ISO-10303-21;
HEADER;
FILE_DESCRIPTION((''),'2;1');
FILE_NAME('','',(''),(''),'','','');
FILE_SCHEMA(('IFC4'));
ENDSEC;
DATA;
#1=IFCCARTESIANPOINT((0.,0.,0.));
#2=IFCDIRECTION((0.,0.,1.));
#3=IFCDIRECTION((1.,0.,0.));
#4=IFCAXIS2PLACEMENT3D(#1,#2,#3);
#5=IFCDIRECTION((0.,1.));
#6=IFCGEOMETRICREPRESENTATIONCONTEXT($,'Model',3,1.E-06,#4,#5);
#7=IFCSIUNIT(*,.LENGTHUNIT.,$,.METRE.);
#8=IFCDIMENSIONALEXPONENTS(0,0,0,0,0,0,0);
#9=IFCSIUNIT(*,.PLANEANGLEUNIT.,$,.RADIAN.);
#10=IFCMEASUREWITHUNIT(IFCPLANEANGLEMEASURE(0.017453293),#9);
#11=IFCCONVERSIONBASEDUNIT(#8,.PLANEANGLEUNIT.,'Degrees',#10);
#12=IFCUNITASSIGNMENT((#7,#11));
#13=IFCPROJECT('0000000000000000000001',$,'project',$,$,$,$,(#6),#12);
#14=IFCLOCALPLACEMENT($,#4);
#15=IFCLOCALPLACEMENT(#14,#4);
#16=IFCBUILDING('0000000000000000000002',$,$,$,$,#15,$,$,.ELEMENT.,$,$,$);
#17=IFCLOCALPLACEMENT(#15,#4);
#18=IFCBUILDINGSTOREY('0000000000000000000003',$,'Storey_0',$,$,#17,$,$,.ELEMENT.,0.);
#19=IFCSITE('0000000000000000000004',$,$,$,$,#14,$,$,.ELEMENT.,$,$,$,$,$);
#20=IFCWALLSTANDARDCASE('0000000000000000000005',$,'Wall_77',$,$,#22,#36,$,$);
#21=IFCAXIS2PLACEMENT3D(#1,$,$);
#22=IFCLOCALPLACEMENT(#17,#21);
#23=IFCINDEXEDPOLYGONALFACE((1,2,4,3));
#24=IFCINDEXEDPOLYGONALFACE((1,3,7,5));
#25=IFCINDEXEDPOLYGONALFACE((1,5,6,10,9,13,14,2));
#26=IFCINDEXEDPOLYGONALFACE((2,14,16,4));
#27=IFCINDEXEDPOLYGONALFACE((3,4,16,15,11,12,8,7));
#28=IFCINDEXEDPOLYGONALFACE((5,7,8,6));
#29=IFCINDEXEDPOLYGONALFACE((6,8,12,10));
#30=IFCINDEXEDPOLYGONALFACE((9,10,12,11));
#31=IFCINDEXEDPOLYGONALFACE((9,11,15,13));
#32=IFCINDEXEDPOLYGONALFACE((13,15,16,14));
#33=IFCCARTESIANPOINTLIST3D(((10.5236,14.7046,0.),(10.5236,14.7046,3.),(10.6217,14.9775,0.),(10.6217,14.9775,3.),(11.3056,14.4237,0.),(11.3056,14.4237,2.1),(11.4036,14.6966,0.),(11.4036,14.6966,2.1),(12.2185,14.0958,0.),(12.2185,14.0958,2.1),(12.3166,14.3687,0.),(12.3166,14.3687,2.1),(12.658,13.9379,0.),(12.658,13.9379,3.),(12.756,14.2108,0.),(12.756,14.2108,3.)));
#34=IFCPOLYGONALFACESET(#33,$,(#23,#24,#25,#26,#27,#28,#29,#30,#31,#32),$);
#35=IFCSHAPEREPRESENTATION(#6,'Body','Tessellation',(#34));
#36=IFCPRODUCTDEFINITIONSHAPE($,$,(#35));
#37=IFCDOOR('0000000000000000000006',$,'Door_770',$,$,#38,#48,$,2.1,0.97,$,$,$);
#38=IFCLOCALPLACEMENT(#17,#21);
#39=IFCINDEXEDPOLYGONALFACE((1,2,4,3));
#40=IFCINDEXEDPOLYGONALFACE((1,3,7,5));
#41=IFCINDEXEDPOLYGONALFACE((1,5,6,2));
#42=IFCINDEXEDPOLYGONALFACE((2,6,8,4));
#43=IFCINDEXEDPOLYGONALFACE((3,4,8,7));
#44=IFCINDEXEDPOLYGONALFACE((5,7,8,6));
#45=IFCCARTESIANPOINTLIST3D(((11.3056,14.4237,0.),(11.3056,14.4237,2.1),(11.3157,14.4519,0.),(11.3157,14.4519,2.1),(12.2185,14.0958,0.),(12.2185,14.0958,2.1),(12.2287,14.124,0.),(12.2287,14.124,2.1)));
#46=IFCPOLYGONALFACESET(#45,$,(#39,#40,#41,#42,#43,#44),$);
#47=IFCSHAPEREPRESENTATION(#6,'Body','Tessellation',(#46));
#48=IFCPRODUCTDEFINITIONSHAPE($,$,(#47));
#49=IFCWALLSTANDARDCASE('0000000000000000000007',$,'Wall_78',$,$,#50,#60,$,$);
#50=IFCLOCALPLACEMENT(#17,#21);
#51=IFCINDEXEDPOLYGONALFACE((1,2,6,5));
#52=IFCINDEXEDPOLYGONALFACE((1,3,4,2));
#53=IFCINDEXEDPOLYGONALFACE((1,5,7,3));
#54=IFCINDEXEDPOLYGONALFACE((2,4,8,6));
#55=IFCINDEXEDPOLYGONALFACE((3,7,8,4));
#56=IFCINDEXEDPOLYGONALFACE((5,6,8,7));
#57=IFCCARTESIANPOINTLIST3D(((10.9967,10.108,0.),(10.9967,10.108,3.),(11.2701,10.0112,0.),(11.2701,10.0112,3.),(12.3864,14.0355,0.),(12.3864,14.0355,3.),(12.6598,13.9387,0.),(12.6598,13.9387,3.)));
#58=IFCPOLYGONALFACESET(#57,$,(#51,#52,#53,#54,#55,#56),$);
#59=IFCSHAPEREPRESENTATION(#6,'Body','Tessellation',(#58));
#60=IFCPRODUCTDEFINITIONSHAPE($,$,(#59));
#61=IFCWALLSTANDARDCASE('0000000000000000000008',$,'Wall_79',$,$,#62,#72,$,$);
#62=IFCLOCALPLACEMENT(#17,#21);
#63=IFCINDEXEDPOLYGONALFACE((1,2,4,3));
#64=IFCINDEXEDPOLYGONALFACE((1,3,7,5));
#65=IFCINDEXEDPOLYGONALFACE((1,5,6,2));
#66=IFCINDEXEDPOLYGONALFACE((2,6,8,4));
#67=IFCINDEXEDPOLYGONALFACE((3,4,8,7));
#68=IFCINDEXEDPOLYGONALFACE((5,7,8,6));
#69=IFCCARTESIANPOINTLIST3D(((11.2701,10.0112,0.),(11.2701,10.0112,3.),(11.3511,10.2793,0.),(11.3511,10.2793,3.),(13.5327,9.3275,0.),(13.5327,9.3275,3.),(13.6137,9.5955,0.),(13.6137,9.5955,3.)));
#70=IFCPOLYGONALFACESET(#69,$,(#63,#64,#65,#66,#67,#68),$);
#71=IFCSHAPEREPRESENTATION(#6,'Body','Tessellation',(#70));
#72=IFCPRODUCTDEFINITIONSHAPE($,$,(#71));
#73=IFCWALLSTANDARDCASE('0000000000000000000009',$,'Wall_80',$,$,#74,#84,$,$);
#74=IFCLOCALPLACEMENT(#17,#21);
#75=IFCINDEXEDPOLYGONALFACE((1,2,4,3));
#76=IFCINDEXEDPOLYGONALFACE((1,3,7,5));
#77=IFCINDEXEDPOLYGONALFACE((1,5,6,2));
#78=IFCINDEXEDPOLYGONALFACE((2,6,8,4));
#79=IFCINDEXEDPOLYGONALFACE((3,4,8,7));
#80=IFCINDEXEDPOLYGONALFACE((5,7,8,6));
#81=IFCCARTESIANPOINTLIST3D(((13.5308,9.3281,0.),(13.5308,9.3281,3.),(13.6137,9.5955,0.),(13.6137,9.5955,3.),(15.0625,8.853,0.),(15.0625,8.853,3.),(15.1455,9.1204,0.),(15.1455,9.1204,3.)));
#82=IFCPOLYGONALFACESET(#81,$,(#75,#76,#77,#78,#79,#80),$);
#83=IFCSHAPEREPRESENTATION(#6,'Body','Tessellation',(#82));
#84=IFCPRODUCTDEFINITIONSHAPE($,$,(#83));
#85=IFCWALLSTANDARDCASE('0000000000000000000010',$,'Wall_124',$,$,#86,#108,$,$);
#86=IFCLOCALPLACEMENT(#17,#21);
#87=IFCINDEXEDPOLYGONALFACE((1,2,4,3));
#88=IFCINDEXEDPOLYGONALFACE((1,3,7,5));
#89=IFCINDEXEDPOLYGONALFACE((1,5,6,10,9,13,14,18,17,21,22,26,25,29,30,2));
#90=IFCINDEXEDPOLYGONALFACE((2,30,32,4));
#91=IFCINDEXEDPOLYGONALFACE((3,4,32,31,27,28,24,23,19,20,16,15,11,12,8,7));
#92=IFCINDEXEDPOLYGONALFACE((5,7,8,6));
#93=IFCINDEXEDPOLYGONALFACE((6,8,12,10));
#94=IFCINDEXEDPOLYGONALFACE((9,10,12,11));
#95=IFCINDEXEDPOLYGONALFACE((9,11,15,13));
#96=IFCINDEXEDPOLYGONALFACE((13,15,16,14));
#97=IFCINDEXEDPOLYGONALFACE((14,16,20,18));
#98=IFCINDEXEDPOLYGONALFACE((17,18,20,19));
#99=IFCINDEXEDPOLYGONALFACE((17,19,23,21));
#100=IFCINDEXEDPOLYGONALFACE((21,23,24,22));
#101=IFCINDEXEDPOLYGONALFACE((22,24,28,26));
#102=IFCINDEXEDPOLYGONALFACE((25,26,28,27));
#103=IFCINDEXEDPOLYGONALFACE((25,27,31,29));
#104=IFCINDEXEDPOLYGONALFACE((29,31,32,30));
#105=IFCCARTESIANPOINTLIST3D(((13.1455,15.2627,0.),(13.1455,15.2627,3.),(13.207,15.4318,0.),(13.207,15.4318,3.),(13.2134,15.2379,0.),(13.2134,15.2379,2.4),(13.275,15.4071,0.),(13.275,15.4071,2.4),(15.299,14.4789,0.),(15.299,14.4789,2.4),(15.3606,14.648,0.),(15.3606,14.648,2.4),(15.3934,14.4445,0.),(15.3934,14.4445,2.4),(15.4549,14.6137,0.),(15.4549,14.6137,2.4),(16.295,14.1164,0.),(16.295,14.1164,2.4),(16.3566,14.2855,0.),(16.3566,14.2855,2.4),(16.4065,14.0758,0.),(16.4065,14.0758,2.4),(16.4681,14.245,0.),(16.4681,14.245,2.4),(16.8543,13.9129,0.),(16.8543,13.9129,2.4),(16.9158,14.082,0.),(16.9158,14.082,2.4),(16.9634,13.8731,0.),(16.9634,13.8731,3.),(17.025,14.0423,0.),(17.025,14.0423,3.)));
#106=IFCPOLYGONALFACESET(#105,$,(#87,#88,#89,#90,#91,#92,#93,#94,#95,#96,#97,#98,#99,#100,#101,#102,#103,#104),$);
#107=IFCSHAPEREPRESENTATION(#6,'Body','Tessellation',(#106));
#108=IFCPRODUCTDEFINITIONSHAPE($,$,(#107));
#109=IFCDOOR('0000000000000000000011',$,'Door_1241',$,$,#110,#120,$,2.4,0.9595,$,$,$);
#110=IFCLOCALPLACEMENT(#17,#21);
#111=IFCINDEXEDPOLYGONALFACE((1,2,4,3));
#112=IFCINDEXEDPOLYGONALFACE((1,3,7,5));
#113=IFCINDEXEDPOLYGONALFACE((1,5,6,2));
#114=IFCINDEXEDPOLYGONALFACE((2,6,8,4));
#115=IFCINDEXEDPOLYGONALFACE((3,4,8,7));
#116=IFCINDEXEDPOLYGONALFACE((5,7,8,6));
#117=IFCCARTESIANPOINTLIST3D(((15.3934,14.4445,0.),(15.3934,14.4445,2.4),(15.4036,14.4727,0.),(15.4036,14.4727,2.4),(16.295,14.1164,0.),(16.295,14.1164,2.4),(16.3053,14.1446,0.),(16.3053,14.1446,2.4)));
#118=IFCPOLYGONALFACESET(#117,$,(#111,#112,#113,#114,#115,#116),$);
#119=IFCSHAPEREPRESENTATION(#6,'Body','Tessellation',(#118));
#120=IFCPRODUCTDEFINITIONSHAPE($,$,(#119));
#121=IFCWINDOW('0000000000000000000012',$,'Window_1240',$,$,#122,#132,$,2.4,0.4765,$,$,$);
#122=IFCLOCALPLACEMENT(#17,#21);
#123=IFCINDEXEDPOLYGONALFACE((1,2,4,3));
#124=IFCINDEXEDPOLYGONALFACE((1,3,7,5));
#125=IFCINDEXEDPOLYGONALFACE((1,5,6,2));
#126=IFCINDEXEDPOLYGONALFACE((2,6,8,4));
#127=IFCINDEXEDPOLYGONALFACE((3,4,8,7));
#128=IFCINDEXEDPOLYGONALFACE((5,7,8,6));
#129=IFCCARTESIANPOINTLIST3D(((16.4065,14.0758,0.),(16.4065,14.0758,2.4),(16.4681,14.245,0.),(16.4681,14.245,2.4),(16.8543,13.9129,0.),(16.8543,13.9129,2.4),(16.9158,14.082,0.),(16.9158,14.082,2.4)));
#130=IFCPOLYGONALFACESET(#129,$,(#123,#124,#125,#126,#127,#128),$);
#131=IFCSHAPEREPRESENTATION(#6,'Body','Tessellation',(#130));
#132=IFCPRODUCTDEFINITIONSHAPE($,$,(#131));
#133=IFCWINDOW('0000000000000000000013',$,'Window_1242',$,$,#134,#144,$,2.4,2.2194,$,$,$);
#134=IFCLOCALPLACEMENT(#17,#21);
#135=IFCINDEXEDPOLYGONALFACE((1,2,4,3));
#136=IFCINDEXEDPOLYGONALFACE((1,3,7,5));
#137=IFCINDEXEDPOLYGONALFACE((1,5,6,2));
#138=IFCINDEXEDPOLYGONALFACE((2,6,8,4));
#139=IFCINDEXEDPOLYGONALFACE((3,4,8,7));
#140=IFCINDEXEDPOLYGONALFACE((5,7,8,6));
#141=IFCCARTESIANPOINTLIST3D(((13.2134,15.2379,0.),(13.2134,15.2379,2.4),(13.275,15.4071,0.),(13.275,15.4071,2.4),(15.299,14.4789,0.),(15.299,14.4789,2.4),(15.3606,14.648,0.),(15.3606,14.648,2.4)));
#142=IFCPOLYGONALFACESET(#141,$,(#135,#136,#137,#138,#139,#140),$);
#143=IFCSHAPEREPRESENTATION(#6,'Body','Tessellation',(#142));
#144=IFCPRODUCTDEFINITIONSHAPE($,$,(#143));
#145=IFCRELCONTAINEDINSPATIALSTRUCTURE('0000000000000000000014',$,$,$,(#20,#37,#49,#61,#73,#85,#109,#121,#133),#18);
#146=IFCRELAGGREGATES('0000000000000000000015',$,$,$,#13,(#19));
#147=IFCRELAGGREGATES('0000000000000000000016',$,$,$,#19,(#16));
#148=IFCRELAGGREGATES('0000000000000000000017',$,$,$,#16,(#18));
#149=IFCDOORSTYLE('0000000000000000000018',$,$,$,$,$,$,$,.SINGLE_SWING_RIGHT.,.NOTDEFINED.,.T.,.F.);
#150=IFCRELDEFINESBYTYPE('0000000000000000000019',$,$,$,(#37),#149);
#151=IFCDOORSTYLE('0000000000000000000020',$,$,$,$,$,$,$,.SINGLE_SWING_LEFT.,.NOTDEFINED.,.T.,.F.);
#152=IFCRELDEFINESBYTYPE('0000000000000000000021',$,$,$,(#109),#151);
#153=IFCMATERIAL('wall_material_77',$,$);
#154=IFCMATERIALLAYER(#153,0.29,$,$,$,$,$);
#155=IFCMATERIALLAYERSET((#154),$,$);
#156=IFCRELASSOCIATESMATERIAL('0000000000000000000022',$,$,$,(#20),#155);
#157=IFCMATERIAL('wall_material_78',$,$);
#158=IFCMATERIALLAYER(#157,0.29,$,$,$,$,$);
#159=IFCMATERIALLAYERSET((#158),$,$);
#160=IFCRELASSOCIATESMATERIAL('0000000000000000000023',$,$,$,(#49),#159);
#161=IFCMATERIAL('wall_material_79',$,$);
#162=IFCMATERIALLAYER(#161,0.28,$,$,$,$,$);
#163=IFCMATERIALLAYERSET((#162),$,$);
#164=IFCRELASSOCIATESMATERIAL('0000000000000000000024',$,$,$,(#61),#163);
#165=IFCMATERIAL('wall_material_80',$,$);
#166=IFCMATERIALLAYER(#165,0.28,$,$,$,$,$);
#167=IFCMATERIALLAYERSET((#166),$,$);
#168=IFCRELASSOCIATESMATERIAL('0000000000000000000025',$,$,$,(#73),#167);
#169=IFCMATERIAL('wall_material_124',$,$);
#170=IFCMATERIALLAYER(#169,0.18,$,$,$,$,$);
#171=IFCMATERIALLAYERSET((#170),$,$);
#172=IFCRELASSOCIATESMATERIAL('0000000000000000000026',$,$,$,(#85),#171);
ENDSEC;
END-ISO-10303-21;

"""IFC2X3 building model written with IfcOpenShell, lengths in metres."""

from ifc_helpers import new_model, entity, si_unit, converted_unit, direction, frame, frame_2d, origin_with_axes, place, context, project, spatial, polyline, rectangle, outline, extrude, material, layer, layer_set, layer_usage, type_object, element, fill, save


model = new_model("IFC2X3")

# Units and contexts
model_context = context("Model", 3, precision=1e-06, world=origin_with_axes(), true_north=direction((0.0, 1.0)))
ifc_project = project(units=[si_unit("LENGTHUNIT", "METRE"), converted_unit("PLANEANGLEUNIT", "Degrees", entity("IfcPlaneAngleMeasure", 0.017453293), si_unit("PLANEANGLEUNIT", "RADIAN"), dimensions=[0, 0, 0, 0, 0, 0, 0])], contexts=[model_context])

# Site, building, storey
site_placement = place(None, origin_with_axes())
site = spatial("IfcSite", under=ifc_project, at=site_placement, CompositionType="ELEMENT")
building_placement = place(site_placement, origin_with_axes())
building = spatial("IfcBuilding", under=site, at=building_placement, CompositionType="ELEMENT")
storey_placement = place(building_placement, origin_with_axes())
storey = spatial("IfcBuildingStorey", under=building, at=storey_placement, Name="Storey_0", CompositionType="ELEMENT", Elevation=0.0)

# Wall, opening, door
ifc_material_1 = material(Name="wall_material_77")
ifc_layer_1 = layer(ifc_material_1, 0.29)
ifc_layer_set_1 = layer_set([ifc_layer_1])
ifc_layer_usage_1 = layer_usage(ifc_layer_set_1, "AXIS2", "POSITIVE", 0.0)
wall_1_placement = place(storey_placement, frame((12.756, 14.2108, 0.0), z_axis=(0.0, 0.0, 1.0), x_axis=(-0.941123, 0.338064, 0.0)))
wall_1 = element("IfcWallStandardCase", 1, at=wall_1_placement, inside=storey, material=ifc_layer_usage_1, Name="Wall_77", context=model_context, shape_type="SweptSolid", body=[
    extrude(outline(polyline([(0.0, 0.29), (2.2679, 0.29), (2.2679, 0.0), (0.0, 0.0), (0.0, 0.29)])), origin_with_axes(), (0.0, 0.0, 1.0), 3.0),
])
opening_1_placement = place(wall_1_placement, frame((0.467, 0.29, 0.0), z_axis=(0.0, 0.0, 1.0), x_axis=(1.0, 0.0, 0.0)))
opening_1 = element("IfcOpeningElement", 2, at=opening_1_placement, cuts=wall_1, context=model_context, shape_type="SweptSolid", body=[
    extrude(rectangle(XDim=0.97, YDim=2.1, at=frame_2d((1.05, -0.485), x_axis=(0.0, 1.0))), frame((0.0, 0.01, 0.0), z_axis=(0.0, -1.0, 0.0), x_axis=(0.0, 0.0, 1.0)), (0.0, 0.0, 1.0), 0.31),
])
door_style_1 = type_object("IfcDoorStyle", ConstructionType="NOTDEFINED", OperationType="SINGLE_SWING_RIGHT", ParameterTakesPrecedence=True, Sizeable=False)
door_1_placement = place(storey_placement, origin_with_axes())
door_1 = element("IfcDoor", 3, at=door_1_placement, inside=storey, type_object=door_style_1, Name="Door_770", OverallHeight=2.1, OverallWidth=0.97, context=model_context, shape_type="SweptSolid", body=[
    extrude(outline(polyline([(12.2185, 14.0958), (11.3056, 14.4237), (11.3157, 14.4519), (12.2287, 14.124), (12.2185, 14.0958)])), origin_with_axes(), (0.0, 0.0, 1.0), 2.1),
])
fill(opening_1, door_1)

# Walls
ifc_material_2 = material(Name="wall_material_78")
ifc_layer_2 = layer(ifc_material_2, 0.29)
ifc_layer_set_2 = layer_set([ifc_layer_2])
ifc_layer_usage_2 = layer_usage(ifc_layer_set_2, "AXIS2", "NEGATIVE", 0.0)
wall_2_placement = place(storey_placement, frame((12.6598, 13.9387, 0.0), z_axis=(0.0, 0.0, 1.0), x_axis=(-0.333565, -0.942727, 0.0)))
element("IfcWallStandardCase", 4, at=wall_2_placement, inside=storey, material=ifc_layer_usage_2, Name="Wall_78", context=model_context, shape_type="SweptSolid", body=[
    extrude(outline(polyline([(0.0, 0.0), (4.1661, 0.0), (4.1661, -0.29), (0.0, -0.29), (0.0, 0.0)])), origin_with_axes(), (0.0, 0.0, 1.0), 3.0),
])
ifc_material_3 = material(Name="wall_material_79")
ifc_layer_3 = layer(ifc_material_3, 0.28)
ifc_layer_set_3 = layer_set([ifc_layer_3])
ifc_layer_usage_3 = layer_usage(ifc_layer_set_3, "AXIS2", "NEGATIVE", 0.0)
wall_3_placement = place(storey_placement, frame((11.3511, 10.2793, 0.0), z_axis=(0.0, 0.0, 1.0), x_axis=(0.957249, -0.289266, 0.0)))
element("IfcWallStandardCase", 5, at=wall_3_placement, inside=storey, material=ifc_layer_usage_3, Name="Wall_79", context=model_context, shape_type="SweptSolid", body=[
    extrude(outline(polyline([(0.0, 0.0), (2.3637, 0.0), (2.3637, -0.28), (0.0, -0.28), (0.0, 0.0)])), origin_with_axes(), (0.0, 0.0, 1.0), 3.0),
])
ifc_material_4 = material(Name="wall_material_80")
ifc_layer_4 = layer(ifc_material_4, 0.28)
ifc_layer_set_4 = layer_set([ifc_layer_4])
ifc_layer_usage_4 = layer_usage(ifc_layer_set_4, "AXIS2", "NEGATIVE", 0.0)
wall_4_placement = place(storey_placement, frame((13.6137, 9.5955, 0.0), z_axis=(0.0, 0.0, 1.0), x_axis=(0.955112, -0.296246, 0.0)))
element("IfcWallStandardCase", 6, at=wall_4_placement, inside=storey, material=ifc_layer_usage_4, Name="Wall_80", context=model_context, shape_type="SweptSolid", body=[
    extrude(outline(polyline([(0.0, 0.0), (1.6038, 0.0), (1.6038, -0.28), (0.0, -0.28), (0.0, 0.0)])), origin_with_axes(), (0.0, 0.0, 1.0), 3.0),
])

# Wall, openings, door, windows
ifc_material_5 = material(Name="wall_material_124")
ifc_layer_5 = layer(ifc_material_5, 0.18)
ifc_layer_set_5 = layer_set([ifc_layer_5])
ifc_layer_usage_5 = layer_usage(ifc_layer_set_5, "AXIS2", "NEGATIVE", 0.0)
wall_5_placement = place(storey_placement, frame((16.9634, 13.8731, 0.0), z_axis=(0.0, 0.0, 1.0), x_axis=(-0.939701, 0.341998, 0.0)))
wall_5 = element("IfcWallStandardCase", 7, at=wall_5_placement, inside=storey, material=ifc_layer_usage_5, Name="Wall_124", context=model_context, shape_type="SweptSolid", body=[
    extrude(outline(polyline([(0.0, 0.0), (4.063, 0.0), (4.063, -0.18), (0.0, -0.18), (0.0, 0.0)])), origin_with_axes(), (0.0, 0.0, 1.0), 3.0),
])
opening_2_placement = place(wall_5_placement, frame((0.1162, 0.0, 0.0), z_axis=(0.0, 0.0, 1.0), x_axis=(1.0, 0.0, 0.0)))
opening_2 = element("IfcOpeningElement", 8, at=opening_2_placement, cuts=wall_5, context=model_context, shape_type="SweptSolid", body=[
    extrude(rectangle(XDim=0.4765, YDim=2.4, at=frame_2d((1.2, -0.2382), x_axis=(0.0, 1.0))), frame((0.0, 0.01, 0.0), z_axis=(0.0, -1.0, 0.0), x_axis=(0.0, 0.0, 1.0)), (0.0, 0.0, 1.0), 0.2),
])
opening_3_placement = place(wall_5_placement, frame((0.7113, 0.0, 0.0), z_axis=(0.0, 0.0, 1.0), x_axis=(1.0, 0.0, 0.0)))
opening_3 = element("IfcOpeningElement", 9, at=opening_3_placement, cuts=wall_5, context=model_context, shape_type="SweptSolid", body=[
    extrude(rectangle(XDim=0.9595, YDim=2.4, at=frame_2d((1.2, -0.4797), x_axis=(0.0, 1.0))), frame((0.0, 0.01, 0.0), z_axis=(0.0, -1.0, 0.0), x_axis=(0.0, 0.0, 1.0)), (0.0, 0.0, 1.0), 0.2),
])
opening_4_placement = place(wall_5_placement, frame((1.7712, 0.0, 0.0), z_axis=(0.0, 0.0, 1.0), x_axis=(1.0, 0.0, 0.0)))
opening_4 = element("IfcOpeningElement", 10, at=opening_4_placement, cuts=wall_5, context=model_context, shape_type="SweptSolid", body=[
    extrude(rectangle(XDim=2.2194, YDim=2.4, at=frame_2d((1.2, -1.1097), x_axis=(0.0, 1.0))), frame((0.0, 0.01, 0.0), z_axis=(0.0, -1.0, 0.0), x_axis=(0.0, 0.0, 1.0)), (0.0, 0.0, 1.0), 0.2),
])
door_style_2 = type_object("IfcDoorStyle", ConstructionType="NOTDEFINED", OperationType="SINGLE_SWING_LEFT", ParameterTakesPrecedence=True, Sizeable=False)
door_2_placement = place(storey_placement, origin_with_axes())
door_2 = element("IfcDoor", 11, at=door_2_placement, inside=storey, type_object=door_style_2, Name="Door_1241", OverallHeight=2.4, OverallWidth=0.9595, context=model_context, shape_type="SweptSolid", body=[
    extrude(outline(polyline([(16.295, 14.1164), (15.3934, 14.4445), (15.4036, 14.4727), (16.3053, 14.1446), (16.295, 14.1164)])), origin_with_axes(), (0.0, 0.0, 1.0), 2.4),
])
fill(opening_3, door_2)
window_1_placement = place(storey_placement, origin_with_axes())
window_1 = element("IfcWindow", 12, at=window_1_placement, inside=storey, Name="Window_1240", OverallHeight=2.4, OverallWidth=0.4765, context=model_context, shape_type="SweptSolid", body=[
    extrude(outline(polyline([(16.8543, 13.9129), (16.4065, 14.0758), (16.4681, 14.245), (16.9158, 14.082), (16.8543, 13.9129)])), origin_with_axes(), (0.0, 0.0, 1.0), 2.4),
])
fill(opening_2, window_1)
window_2_placement = place(storey_placement, origin_with_axes())
window_2 = element("IfcWindow", 13, at=window_2_placement, inside=storey, Name="Window_1242", OverallHeight=2.4, OverallWidth=2.2194, context=model_context, shape_type="SweptSolid", body=[
    extrude(outline(polyline([(15.299, 14.4789), (13.2134, 15.2379), (13.275, 15.4071), (15.3606, 14.648), (15.299, 14.4789)])), origin_with_axes(), (0.0, 0.0, 1.0), 2.4),
])
fill(opening_4, window_2)

save(model, "model.ifc")
